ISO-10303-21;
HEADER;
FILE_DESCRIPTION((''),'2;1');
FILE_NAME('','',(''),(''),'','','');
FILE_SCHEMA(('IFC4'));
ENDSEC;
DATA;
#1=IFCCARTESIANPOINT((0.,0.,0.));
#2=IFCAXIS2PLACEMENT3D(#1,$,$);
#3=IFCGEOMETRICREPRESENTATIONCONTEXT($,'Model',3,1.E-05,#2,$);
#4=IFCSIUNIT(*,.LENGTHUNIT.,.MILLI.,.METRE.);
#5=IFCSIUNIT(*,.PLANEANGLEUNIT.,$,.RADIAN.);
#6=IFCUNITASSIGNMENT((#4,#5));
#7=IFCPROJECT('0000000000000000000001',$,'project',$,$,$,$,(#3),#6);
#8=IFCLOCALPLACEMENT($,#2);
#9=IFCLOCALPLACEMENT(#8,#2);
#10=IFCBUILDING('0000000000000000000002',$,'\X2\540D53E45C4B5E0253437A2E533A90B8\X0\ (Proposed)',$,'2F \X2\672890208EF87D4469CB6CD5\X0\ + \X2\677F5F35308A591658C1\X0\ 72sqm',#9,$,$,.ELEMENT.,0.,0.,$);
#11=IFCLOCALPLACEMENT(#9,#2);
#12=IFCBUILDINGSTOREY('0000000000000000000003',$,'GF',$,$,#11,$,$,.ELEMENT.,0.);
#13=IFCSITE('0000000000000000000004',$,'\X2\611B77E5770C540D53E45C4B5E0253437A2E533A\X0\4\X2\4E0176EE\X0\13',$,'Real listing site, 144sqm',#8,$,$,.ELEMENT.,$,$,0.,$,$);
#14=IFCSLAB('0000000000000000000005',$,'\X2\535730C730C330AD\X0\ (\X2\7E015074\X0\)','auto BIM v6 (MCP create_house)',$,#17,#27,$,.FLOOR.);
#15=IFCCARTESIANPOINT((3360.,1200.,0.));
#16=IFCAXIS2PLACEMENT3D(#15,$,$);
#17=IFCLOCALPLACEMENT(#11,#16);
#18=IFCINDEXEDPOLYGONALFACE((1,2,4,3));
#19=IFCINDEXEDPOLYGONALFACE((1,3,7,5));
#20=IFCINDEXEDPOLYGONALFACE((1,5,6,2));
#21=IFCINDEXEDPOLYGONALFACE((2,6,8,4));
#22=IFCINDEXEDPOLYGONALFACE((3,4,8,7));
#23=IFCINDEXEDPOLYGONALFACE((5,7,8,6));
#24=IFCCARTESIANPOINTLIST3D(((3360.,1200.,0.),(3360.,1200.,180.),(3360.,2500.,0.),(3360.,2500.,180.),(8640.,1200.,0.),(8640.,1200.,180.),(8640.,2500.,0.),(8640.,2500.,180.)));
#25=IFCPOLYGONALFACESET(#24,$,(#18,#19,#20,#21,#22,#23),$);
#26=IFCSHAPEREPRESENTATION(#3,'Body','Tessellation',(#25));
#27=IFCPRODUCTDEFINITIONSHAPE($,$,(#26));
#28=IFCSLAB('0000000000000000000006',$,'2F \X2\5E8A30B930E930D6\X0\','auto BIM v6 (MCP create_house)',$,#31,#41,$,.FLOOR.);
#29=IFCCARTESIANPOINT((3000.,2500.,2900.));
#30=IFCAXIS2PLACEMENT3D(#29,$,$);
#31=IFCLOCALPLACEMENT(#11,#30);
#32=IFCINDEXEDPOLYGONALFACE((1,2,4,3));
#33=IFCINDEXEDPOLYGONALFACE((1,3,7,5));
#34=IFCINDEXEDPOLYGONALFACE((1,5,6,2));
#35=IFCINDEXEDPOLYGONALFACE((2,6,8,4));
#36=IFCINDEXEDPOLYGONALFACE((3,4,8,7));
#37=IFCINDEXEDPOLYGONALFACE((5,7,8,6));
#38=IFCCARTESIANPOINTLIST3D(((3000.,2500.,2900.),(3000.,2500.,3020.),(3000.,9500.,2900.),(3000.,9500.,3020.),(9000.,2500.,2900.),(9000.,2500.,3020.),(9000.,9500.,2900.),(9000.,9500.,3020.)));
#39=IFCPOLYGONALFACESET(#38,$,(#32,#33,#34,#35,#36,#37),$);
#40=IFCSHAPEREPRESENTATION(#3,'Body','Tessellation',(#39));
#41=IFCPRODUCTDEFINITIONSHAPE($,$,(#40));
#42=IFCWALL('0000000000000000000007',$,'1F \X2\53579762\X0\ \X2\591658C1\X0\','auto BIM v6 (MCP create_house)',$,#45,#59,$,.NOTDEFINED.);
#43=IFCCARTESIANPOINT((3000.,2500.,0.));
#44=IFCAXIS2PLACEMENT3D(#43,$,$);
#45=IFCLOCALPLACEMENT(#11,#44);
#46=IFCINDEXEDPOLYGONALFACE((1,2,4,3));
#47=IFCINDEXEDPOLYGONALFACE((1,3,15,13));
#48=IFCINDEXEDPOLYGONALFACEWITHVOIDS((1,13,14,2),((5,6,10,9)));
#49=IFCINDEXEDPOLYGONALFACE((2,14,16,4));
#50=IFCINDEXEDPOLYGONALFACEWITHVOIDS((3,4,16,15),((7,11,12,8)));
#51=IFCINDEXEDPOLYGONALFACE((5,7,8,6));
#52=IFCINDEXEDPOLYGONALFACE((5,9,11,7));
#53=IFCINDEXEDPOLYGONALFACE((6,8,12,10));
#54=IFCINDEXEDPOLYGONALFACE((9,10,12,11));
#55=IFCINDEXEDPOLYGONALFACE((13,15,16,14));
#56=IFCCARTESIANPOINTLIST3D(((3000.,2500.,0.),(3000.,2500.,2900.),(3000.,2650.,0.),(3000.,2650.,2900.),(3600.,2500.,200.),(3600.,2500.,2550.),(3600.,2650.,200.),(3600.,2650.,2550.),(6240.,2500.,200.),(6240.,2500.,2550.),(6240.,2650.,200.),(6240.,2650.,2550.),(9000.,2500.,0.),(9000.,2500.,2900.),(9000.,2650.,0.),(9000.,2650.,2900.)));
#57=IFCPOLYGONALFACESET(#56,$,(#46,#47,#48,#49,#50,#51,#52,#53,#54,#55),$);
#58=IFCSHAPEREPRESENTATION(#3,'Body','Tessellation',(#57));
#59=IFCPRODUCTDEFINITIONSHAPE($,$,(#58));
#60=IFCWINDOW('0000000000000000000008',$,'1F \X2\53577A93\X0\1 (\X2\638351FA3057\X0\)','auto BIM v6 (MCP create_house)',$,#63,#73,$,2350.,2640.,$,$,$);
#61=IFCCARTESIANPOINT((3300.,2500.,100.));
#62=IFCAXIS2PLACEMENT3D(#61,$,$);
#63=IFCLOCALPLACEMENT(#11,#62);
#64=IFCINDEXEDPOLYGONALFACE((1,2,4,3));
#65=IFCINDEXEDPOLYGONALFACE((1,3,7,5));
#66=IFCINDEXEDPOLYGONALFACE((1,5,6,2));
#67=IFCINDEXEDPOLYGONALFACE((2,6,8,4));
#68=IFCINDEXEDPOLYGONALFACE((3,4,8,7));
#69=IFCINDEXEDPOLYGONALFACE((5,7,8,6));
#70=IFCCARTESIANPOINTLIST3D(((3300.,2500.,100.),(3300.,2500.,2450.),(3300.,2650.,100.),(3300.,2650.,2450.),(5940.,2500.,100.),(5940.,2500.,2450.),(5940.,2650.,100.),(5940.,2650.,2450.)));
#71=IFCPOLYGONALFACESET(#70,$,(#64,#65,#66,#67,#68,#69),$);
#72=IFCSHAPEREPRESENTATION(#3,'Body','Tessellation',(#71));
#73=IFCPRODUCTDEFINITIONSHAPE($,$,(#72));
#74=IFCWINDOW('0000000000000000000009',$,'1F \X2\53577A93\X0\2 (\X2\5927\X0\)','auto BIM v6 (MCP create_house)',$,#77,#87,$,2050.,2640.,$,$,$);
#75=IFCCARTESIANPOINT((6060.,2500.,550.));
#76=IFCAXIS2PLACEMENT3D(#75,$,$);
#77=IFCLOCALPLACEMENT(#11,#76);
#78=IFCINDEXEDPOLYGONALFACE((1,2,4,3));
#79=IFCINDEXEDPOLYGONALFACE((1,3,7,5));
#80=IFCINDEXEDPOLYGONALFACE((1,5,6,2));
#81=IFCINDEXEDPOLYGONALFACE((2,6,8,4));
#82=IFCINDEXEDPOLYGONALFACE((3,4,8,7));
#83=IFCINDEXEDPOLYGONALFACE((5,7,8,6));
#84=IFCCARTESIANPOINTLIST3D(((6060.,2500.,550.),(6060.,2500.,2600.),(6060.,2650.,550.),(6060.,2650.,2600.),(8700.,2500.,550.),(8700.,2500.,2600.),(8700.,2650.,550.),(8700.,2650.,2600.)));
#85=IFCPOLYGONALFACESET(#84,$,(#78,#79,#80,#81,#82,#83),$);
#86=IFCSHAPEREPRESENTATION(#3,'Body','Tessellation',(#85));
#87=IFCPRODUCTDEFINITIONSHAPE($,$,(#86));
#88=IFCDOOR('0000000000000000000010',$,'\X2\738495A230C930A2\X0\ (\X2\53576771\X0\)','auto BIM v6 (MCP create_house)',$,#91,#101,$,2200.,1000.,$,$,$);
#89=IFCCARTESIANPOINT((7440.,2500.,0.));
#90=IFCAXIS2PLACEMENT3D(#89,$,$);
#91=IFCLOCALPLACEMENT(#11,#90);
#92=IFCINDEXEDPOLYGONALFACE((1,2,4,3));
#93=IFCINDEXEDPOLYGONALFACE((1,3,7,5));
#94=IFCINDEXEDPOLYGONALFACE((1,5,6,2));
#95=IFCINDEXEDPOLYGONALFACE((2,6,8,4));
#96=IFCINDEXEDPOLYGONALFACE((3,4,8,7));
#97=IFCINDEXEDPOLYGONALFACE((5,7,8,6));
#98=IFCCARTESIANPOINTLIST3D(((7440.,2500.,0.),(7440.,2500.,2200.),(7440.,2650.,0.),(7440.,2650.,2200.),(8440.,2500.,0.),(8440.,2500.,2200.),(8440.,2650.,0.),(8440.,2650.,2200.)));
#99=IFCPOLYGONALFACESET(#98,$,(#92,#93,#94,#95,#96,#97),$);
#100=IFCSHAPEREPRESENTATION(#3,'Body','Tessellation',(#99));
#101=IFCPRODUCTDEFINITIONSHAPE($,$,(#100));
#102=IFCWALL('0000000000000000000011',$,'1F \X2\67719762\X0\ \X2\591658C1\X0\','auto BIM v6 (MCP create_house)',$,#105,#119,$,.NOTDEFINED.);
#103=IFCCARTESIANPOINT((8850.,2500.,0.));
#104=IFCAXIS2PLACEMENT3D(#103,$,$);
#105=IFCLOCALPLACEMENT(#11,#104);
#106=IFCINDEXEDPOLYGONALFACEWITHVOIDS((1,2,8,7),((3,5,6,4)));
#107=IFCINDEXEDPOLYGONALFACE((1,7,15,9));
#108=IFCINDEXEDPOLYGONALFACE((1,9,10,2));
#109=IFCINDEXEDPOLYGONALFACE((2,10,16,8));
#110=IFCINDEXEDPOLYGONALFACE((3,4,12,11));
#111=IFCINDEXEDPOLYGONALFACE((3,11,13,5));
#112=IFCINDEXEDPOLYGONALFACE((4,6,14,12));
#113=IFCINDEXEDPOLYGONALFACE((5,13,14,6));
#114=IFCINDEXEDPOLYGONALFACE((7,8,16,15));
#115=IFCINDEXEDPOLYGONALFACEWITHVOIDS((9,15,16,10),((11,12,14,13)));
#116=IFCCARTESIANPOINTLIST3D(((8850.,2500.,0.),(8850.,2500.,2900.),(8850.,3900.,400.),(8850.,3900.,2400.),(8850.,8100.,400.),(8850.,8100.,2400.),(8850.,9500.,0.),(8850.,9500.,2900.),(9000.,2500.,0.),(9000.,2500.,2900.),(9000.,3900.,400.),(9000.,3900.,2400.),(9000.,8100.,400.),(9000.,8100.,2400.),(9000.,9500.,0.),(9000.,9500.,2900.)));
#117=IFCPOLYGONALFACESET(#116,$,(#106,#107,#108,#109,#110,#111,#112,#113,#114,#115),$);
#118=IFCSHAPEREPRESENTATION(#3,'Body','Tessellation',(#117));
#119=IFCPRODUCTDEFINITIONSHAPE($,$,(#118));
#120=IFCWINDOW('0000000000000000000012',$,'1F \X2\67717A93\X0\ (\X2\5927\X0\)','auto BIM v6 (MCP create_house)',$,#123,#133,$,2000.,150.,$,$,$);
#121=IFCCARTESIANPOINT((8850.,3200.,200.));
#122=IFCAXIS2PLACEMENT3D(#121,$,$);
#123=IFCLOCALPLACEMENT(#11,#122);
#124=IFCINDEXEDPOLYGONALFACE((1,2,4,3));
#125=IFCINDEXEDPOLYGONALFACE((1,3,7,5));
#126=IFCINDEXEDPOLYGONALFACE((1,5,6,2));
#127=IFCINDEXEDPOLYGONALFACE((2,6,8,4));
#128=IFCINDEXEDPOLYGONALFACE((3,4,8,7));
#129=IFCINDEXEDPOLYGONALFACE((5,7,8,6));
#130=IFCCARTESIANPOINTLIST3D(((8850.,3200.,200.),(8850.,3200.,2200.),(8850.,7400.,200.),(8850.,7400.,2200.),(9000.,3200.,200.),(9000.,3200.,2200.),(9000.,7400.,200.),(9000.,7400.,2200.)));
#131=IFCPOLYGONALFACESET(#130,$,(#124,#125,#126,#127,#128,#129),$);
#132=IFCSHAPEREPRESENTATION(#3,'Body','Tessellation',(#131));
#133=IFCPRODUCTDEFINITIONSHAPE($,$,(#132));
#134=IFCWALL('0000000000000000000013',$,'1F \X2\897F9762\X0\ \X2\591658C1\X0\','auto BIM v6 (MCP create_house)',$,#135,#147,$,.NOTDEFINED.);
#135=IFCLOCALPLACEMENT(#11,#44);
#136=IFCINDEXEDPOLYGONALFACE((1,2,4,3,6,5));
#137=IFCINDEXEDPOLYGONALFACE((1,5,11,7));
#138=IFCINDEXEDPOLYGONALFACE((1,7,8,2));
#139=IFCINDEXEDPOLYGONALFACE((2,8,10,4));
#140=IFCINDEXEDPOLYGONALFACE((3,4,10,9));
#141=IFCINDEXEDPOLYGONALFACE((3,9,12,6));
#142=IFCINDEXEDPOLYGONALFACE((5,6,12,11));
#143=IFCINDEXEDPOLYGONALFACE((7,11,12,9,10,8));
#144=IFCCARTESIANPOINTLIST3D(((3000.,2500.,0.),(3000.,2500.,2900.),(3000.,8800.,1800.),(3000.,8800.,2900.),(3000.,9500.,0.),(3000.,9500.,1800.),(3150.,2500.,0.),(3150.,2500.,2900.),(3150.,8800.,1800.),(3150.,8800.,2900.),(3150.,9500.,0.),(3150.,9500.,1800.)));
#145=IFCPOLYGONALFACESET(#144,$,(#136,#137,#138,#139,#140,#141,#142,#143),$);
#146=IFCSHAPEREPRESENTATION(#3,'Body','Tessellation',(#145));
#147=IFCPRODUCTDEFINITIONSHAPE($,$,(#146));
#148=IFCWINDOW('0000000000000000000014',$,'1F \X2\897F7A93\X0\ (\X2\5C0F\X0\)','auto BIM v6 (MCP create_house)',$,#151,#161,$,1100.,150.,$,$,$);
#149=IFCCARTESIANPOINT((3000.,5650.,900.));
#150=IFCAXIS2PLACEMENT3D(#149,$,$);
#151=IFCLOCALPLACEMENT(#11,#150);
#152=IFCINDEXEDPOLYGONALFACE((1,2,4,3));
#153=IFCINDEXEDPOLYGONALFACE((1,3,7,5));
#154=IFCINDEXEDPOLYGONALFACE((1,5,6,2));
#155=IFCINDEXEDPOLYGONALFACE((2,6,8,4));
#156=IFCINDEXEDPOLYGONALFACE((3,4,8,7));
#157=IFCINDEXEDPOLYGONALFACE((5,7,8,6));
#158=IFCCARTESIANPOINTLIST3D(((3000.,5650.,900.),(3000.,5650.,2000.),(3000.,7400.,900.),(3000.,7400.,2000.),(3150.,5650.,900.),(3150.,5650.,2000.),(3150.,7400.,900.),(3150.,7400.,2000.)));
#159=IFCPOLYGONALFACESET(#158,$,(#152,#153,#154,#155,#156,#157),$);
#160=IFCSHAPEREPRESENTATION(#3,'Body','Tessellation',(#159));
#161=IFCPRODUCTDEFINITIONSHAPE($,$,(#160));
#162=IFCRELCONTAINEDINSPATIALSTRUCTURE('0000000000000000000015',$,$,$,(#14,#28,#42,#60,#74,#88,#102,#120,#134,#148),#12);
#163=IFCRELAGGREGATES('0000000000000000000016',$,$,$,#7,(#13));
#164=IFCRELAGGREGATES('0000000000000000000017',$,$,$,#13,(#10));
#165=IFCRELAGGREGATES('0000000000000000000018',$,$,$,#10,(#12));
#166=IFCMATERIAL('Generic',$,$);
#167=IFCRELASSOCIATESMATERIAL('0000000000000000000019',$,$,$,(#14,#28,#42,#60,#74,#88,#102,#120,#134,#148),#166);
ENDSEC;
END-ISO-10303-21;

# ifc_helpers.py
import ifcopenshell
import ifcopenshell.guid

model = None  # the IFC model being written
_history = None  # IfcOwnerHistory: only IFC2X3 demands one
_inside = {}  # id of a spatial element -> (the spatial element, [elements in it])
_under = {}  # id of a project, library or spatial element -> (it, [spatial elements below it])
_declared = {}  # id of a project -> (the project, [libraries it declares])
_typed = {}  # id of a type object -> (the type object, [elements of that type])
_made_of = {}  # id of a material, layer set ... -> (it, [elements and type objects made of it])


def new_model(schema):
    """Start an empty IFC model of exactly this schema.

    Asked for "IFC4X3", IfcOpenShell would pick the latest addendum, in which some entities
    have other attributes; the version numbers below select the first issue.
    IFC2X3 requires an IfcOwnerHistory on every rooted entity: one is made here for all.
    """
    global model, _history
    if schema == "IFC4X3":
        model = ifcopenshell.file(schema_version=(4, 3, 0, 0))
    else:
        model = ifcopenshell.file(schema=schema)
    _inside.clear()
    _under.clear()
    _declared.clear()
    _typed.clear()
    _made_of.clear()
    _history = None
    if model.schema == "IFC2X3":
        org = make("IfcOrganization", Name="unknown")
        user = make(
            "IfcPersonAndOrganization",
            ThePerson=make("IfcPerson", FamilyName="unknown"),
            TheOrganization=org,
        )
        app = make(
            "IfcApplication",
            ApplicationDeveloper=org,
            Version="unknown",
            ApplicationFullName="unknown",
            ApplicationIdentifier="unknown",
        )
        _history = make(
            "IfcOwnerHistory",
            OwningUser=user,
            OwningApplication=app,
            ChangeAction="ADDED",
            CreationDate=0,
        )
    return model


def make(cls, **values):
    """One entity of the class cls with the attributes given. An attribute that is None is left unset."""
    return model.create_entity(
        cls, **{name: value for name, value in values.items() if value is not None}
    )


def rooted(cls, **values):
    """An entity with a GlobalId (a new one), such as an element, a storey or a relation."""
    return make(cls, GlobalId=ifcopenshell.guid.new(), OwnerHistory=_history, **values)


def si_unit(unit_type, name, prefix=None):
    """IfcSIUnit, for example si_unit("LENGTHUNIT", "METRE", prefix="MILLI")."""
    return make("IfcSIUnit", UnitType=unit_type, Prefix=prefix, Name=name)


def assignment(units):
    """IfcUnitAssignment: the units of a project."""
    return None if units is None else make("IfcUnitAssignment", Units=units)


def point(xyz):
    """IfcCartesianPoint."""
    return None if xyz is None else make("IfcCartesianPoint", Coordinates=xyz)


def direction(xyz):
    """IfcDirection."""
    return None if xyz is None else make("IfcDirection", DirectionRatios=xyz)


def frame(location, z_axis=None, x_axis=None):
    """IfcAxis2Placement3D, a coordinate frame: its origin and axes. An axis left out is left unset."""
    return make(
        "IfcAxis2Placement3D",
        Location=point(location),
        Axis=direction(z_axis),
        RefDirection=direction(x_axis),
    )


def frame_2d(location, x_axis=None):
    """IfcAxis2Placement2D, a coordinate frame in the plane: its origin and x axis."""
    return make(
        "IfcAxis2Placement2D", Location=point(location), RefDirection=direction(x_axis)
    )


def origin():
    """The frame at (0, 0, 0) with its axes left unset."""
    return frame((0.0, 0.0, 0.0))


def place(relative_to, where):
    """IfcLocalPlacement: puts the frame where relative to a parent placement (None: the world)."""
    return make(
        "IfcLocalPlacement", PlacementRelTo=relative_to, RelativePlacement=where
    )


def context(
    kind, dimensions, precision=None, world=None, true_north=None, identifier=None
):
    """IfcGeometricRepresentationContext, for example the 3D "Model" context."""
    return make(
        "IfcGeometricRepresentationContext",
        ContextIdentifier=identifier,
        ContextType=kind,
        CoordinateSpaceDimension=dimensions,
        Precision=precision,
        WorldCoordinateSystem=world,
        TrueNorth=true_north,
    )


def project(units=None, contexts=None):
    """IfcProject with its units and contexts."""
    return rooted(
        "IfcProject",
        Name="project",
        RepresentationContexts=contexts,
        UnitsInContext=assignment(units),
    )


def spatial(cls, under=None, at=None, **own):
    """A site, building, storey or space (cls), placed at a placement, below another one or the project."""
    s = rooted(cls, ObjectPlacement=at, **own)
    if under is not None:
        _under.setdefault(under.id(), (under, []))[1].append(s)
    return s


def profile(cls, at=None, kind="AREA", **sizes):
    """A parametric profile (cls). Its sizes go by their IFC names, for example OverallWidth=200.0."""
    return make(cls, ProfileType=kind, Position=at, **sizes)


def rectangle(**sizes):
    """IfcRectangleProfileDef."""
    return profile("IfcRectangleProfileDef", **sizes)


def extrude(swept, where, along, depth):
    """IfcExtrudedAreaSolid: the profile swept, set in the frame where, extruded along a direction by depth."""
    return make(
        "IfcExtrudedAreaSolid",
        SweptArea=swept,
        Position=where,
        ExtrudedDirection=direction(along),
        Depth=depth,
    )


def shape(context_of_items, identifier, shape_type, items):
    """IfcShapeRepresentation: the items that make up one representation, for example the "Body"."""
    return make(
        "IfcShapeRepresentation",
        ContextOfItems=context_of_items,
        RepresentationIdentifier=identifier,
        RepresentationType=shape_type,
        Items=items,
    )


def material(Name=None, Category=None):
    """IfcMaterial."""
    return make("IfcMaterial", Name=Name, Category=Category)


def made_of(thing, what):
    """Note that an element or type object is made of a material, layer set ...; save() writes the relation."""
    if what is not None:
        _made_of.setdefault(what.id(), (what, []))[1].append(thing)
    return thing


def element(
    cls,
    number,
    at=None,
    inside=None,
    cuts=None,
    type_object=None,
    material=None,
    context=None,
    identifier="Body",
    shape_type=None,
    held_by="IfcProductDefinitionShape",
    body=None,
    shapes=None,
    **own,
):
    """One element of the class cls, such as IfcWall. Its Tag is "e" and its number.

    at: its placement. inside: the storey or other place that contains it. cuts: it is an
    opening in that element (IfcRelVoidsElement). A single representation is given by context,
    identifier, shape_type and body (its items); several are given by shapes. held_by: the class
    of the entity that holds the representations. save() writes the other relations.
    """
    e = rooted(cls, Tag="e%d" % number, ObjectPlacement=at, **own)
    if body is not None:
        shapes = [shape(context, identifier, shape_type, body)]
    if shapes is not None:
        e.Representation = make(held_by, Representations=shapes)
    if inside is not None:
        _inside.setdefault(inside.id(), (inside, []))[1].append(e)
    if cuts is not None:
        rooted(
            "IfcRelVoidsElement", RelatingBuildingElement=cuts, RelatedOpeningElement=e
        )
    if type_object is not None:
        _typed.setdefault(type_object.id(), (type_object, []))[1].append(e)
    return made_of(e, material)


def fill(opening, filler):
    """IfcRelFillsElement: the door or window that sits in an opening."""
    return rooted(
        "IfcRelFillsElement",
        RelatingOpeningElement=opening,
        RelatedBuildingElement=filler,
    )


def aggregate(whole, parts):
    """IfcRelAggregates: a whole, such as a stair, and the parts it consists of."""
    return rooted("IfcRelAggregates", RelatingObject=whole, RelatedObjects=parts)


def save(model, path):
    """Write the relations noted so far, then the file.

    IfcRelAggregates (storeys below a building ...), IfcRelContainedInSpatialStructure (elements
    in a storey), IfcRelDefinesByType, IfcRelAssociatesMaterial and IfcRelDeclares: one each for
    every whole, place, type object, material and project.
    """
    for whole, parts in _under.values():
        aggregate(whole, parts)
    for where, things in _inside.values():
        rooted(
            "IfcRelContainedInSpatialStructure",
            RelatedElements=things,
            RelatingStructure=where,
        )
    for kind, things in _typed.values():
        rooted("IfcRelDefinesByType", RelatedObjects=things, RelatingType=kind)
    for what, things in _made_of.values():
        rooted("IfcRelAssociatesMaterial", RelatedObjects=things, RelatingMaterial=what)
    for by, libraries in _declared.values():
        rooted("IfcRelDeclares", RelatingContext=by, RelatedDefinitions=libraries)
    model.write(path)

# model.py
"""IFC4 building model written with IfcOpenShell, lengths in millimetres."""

from ifc_helpers import new_model, si_unit, frame, frame_2d, origin, place, context, project, spatial, rectangle, extrude, material, element, fill, save


model = new_model("IFC4")

# Units and contexts
model_context = context("Model", 3, precision=1e-05, world=origin())
ifc_project = project(units=[si_unit("LENGTHUNIT", "METRE", prefix="MILLI"), si_unit("PLANEANGLEUNIT", "RADIAN")], contexts=[model_context])

# Site, building, storey
site_placement = place(None, origin())
site = spatial("IfcSite", under=ifc_project, at=site_placement, Name="愛知県名古屋市千種区4丁目13", ObjectType="Real listing site, 144sqm", CompositionType="ELEMENT", RefElevation=0.0)
building_placement = place(site_placement, origin())
building = spatial("IfcBuilding", under=site, at=building_placement, Name="名古屋市千種区邸 (Proposed)", ObjectType="2F 木造軸組構法 + 板張り外壁 72sqm", CompositionType="ELEMENT", ElevationOfRefHeight=0.0, ElevationOfTerrain=0.0)
storey_placement = place(building_placement, origin())
storey = spatial("IfcBuildingStorey", under=building, at=storey_placement, Name="GF", CompositionType="ELEMENT", Elevation=0.0)

# Slabs
ifc_material = material(Name="Generic")
slab_1_placement = place(storey_placement, frame((3360.0, 1200.0, 0.0)))
element("IfcSlab", 1, at=slab_1_placement, inside=storey, material=ifc_material, Name="南デッキ (縁側)", Description="auto BIM v6 (MCP create_house)", PredefinedType="FLOOR", context=model_context, shape_type="SweptSolid", body=[
    extrude(rectangle(XDim=5280.0, YDim=1300.0, at=frame_2d((2640.0, 650.0))), frame((3360.0, 1200.0, 0.0)), (0.0, 0.0, 1.0), 180.0),
])
slab_2_placement = place(storey_placement, frame((3000.0, 2500.0, 2900.0)))
element("IfcSlab", 2, at=slab_2_placement, inside=storey, material=ifc_material, Name="2F 床スラブ", Description="auto BIM v6 (MCP create_house)", PredefinedType="FLOOR", context=model_context, shape_type="SweptSolid", body=[
    extrude(rectangle(XDim=6000.0, YDim=7000.0, at=frame_2d((3000.0, 3500.0))), frame((3000.0, 2500.0, 2900.0)), (0.0, 0.0, 1.0), 120.0),
])

# Wall, openings, windows, door
wall_1_placement = place(storey_placement, frame((3000.0, 2500.0, 0.0)))
wall_1 = element("IfcWall", 3, at=wall_1_placement, inside=storey, material=ifc_material, Name="1F 南面 外壁", Description="auto BIM v6 (MCP create_house)", PredefinedType="NOTDEFINED", context=model_context, shape_type="SweptSolid", body=[
    extrude(rectangle(XDim=6000.0, YDim=150.0, at=frame_2d((3000.0, 75.0))), frame((3000.0, 2500.0, 0.0)), (0.0, 0.0, 1.0), 2900.0),
])
opening_1_placement = place(storey_placement, frame((3300.0, 2500.0, 100.0)))
opening_1 = element("IfcOpeningElement", 4, at=opening_1_placement, cuts=wall_1, PredefinedType="NOTDEFINED", context=model_context, shape_type="SweptSolid", body=[
    extrude(rectangle(XDim=2640.0, YDim=150.0, at=frame_2d((1320.0, 75.0))), frame((3300.0, 2500.0, 100.0)), (0.0, 0.0, 1.0), 2350.0),
])
opening_2_placement = place(storey_placement, frame((6060.0, 2500.0, 550.0)))
opening_2 = element("IfcOpeningElement", 5, at=opening_2_placement, cuts=wall_1, PredefinedType="NOTDEFINED", context=model_context, shape_type="SweptSolid", body=[
    extrude(rectangle(XDim=2640.0, YDim=150.0, at=frame_2d((1320.0, 75.0))), frame((6060.0, 2500.0, 550.0)), (0.0, 0.0, 1.0), 2050.0),
])
opening_3_placement = place(storey_placement, frame((7440.0, 2500.0, 0.0)))
opening_3 = element("IfcOpeningElement", 6, at=opening_3_placement, cuts=wall_1, PredefinedType="NOTDEFINED", context=model_context, shape_type="SweptSolid", body=[
    extrude(rectangle(XDim=1000.0, YDim=150.0, at=frame_2d((500.0, 75.0))), frame((7440.0, 2500.0, 0.0)), (0.0, 0.0, 1.0), 2200.0),
])
window_1_placement = place(storey_placement, frame((3300.0, 2500.0, 100.0)))
window_1 = element("IfcWindow", 7, at=window_1_placement, inside=storey, material=ifc_material, Name="1F 南窓1 (掃出し)", Description="auto BIM v6 (MCP create_house)", OverallHeight=2350.0, OverallWidth=2640.0, context=model_context, shape_type="SweptSolid", body=[
    extrude(rectangle(XDim=2640.0, YDim=150.0, at=frame_2d((1320.0, 75.0))), frame((3300.0, 2500.0, 100.0)), (0.0, 0.0, 1.0), 2350.0),
])
fill(opening_1, window_1)
window_2_placement = place(storey_placement, frame((6060.0, 2500.0, 550.0)))
window_2 = element("IfcWindow", 8, at=window_2_placement, inside=storey, material=ifc_material, Name="1F 南窓2 (大)", Description="auto BIM v6 (MCP create_house)", OverallHeight=2050.0, OverallWidth=2640.0, context=model_context, shape_type="SweptSolid", body=[
    extrude(rectangle(XDim=2640.0, YDim=150.0, at=frame_2d((1320.0, 75.0))), frame((6060.0, 2500.0, 550.0)), (0.0, 0.0, 1.0), 2050.0),
])
fill(opening_2, window_2)
door_placement = place(storey_placement, frame((7440.0, 2500.0, 0.0)))
door = element("IfcDoor", 9, at=door_placement, inside=storey, material=ifc_material, Name="玄関ドア (南東)", Description="auto BIM v6 (MCP create_house)", OverallHeight=2200.0, OverallWidth=1000.0, context=model_context, shape_type="SweptSolid", body=[
    extrude(rectangle(XDim=1000.0, YDim=150.0, at=frame_2d((500.0, 75.0))), frame((7440.0, 2500.0, 0.0)), (0.0, 0.0, 1.0), 2200.0),
])
fill(opening_3, door)

# Walls, openings, windows
wall_2_placement = place(storey_placement, frame((8850.0, 2500.0, 0.0)))
wall_2 = element("IfcWall", 10, at=wall_2_placement, inside=storey, material=ifc_material, Name="1F 東面 外壁", Description="auto BIM v6 (MCP create_house)", PredefinedType="NOTDEFINED", context=model_context, shape_type="SweptSolid", body=[
    extrude(rectangle(XDim=150.0, YDim=7000.0, at=frame_2d((75.0, 3500.0))), frame((8850.0, 2500.0, 0.0)), (0.0, 0.0, 1.0), 2900.0),
])
opening_4_placement = place(storey_placement, frame((8850.0, 3200.0, 200.0)))
opening_4 = element("IfcOpeningElement", 11, at=opening_4_placement, cuts=wall_2, PredefinedType="NOTDEFINED", context=model_context, shape_type="SweptSolid", body=[
    extrude(rectangle(XDim=150.0, YDim=4200.0, at=frame_2d((75.0, 2100.0))), frame((8850.0, 3200.0, 200.0)), (0.0, 0.0, 1.0), 2000.0),
])
window_3_placement = place(storey_placement, frame((8850.0, 3200.0, 200.0)))
window_3 = element("IfcWindow", 12, at=window_3_placement, inside=storey, material=ifc_material, Name="1F 東窓 (大)", Description="auto BIM v6 (MCP create_house)", OverallHeight=2000.0, OverallWidth=150.0, context=model_context, shape_type="SweptSolid", body=[
    extrude(rectangle(XDim=150.0, YDim=4200.0, at=frame_2d((75.0, 2100.0))), frame((8850.0, 3200.0, 200.0)), (0.0, 0.0, 1.0), 2000.0),
])
fill(opening_4, window_3)
wall_3_placement = place(storey_placement, frame((3000.0, 2500.0, 0.0)))
wall_3 = element("IfcWall", 13, at=wall_3_placement, inside=storey, material=ifc_material, Name="1F 西面 外壁", Description="auto BIM v6 (MCP create_house)", PredefinedType="NOTDEFINED", context=model_context, shape_type="SweptSolid", body=[
    extrude(rectangle(XDim=150.0, YDim=7000.0, at=frame_2d((75.0, 3500.0))), frame((3000.0, 2500.0, 0.0)), (0.0, 0.0, 1.0), 2900.0),
])
opening_5_placement = place(storey_placement, frame((3000.0, 5650.0, 900.0)))
opening_5 = element("IfcOpeningElement", 14, at=opening_5_placement, cuts=wall_3, PredefinedType="NOTDEFINED", context=model_context, shape_type="SweptSolid", body=[
    extrude(rectangle(XDim=150.0, YDim=1750.0, at=frame_2d((75.0, 875.0))), frame((3000.0, 5650.0, 900.0)), (0.0, 0.0, 1.0), 1100.0),
])
window_4_placement = place(storey_placement, frame((3000.0, 5650.0, 900.0)))
window_4 = element("IfcWindow", 15, at=window_4_placement, inside=storey, material=ifc_material, Name="1F 西窓 (小)", Description="auto BIM v6 (MCP create_house)", OverallHeight=1100.0, OverallWidth=150.0, context=model_context, shape_type="SweptSolid", body=[
    extrude(rectangle(XDim=150.0, YDim=1750.0, at=frame_2d((75.0, 875.0))), frame((3000.0, 5650.0, 900.0)), (0.0, 0.0, 1.0), 1100.0),
])
fill(opening_5, window_4)

save(model, "model.ifc")
